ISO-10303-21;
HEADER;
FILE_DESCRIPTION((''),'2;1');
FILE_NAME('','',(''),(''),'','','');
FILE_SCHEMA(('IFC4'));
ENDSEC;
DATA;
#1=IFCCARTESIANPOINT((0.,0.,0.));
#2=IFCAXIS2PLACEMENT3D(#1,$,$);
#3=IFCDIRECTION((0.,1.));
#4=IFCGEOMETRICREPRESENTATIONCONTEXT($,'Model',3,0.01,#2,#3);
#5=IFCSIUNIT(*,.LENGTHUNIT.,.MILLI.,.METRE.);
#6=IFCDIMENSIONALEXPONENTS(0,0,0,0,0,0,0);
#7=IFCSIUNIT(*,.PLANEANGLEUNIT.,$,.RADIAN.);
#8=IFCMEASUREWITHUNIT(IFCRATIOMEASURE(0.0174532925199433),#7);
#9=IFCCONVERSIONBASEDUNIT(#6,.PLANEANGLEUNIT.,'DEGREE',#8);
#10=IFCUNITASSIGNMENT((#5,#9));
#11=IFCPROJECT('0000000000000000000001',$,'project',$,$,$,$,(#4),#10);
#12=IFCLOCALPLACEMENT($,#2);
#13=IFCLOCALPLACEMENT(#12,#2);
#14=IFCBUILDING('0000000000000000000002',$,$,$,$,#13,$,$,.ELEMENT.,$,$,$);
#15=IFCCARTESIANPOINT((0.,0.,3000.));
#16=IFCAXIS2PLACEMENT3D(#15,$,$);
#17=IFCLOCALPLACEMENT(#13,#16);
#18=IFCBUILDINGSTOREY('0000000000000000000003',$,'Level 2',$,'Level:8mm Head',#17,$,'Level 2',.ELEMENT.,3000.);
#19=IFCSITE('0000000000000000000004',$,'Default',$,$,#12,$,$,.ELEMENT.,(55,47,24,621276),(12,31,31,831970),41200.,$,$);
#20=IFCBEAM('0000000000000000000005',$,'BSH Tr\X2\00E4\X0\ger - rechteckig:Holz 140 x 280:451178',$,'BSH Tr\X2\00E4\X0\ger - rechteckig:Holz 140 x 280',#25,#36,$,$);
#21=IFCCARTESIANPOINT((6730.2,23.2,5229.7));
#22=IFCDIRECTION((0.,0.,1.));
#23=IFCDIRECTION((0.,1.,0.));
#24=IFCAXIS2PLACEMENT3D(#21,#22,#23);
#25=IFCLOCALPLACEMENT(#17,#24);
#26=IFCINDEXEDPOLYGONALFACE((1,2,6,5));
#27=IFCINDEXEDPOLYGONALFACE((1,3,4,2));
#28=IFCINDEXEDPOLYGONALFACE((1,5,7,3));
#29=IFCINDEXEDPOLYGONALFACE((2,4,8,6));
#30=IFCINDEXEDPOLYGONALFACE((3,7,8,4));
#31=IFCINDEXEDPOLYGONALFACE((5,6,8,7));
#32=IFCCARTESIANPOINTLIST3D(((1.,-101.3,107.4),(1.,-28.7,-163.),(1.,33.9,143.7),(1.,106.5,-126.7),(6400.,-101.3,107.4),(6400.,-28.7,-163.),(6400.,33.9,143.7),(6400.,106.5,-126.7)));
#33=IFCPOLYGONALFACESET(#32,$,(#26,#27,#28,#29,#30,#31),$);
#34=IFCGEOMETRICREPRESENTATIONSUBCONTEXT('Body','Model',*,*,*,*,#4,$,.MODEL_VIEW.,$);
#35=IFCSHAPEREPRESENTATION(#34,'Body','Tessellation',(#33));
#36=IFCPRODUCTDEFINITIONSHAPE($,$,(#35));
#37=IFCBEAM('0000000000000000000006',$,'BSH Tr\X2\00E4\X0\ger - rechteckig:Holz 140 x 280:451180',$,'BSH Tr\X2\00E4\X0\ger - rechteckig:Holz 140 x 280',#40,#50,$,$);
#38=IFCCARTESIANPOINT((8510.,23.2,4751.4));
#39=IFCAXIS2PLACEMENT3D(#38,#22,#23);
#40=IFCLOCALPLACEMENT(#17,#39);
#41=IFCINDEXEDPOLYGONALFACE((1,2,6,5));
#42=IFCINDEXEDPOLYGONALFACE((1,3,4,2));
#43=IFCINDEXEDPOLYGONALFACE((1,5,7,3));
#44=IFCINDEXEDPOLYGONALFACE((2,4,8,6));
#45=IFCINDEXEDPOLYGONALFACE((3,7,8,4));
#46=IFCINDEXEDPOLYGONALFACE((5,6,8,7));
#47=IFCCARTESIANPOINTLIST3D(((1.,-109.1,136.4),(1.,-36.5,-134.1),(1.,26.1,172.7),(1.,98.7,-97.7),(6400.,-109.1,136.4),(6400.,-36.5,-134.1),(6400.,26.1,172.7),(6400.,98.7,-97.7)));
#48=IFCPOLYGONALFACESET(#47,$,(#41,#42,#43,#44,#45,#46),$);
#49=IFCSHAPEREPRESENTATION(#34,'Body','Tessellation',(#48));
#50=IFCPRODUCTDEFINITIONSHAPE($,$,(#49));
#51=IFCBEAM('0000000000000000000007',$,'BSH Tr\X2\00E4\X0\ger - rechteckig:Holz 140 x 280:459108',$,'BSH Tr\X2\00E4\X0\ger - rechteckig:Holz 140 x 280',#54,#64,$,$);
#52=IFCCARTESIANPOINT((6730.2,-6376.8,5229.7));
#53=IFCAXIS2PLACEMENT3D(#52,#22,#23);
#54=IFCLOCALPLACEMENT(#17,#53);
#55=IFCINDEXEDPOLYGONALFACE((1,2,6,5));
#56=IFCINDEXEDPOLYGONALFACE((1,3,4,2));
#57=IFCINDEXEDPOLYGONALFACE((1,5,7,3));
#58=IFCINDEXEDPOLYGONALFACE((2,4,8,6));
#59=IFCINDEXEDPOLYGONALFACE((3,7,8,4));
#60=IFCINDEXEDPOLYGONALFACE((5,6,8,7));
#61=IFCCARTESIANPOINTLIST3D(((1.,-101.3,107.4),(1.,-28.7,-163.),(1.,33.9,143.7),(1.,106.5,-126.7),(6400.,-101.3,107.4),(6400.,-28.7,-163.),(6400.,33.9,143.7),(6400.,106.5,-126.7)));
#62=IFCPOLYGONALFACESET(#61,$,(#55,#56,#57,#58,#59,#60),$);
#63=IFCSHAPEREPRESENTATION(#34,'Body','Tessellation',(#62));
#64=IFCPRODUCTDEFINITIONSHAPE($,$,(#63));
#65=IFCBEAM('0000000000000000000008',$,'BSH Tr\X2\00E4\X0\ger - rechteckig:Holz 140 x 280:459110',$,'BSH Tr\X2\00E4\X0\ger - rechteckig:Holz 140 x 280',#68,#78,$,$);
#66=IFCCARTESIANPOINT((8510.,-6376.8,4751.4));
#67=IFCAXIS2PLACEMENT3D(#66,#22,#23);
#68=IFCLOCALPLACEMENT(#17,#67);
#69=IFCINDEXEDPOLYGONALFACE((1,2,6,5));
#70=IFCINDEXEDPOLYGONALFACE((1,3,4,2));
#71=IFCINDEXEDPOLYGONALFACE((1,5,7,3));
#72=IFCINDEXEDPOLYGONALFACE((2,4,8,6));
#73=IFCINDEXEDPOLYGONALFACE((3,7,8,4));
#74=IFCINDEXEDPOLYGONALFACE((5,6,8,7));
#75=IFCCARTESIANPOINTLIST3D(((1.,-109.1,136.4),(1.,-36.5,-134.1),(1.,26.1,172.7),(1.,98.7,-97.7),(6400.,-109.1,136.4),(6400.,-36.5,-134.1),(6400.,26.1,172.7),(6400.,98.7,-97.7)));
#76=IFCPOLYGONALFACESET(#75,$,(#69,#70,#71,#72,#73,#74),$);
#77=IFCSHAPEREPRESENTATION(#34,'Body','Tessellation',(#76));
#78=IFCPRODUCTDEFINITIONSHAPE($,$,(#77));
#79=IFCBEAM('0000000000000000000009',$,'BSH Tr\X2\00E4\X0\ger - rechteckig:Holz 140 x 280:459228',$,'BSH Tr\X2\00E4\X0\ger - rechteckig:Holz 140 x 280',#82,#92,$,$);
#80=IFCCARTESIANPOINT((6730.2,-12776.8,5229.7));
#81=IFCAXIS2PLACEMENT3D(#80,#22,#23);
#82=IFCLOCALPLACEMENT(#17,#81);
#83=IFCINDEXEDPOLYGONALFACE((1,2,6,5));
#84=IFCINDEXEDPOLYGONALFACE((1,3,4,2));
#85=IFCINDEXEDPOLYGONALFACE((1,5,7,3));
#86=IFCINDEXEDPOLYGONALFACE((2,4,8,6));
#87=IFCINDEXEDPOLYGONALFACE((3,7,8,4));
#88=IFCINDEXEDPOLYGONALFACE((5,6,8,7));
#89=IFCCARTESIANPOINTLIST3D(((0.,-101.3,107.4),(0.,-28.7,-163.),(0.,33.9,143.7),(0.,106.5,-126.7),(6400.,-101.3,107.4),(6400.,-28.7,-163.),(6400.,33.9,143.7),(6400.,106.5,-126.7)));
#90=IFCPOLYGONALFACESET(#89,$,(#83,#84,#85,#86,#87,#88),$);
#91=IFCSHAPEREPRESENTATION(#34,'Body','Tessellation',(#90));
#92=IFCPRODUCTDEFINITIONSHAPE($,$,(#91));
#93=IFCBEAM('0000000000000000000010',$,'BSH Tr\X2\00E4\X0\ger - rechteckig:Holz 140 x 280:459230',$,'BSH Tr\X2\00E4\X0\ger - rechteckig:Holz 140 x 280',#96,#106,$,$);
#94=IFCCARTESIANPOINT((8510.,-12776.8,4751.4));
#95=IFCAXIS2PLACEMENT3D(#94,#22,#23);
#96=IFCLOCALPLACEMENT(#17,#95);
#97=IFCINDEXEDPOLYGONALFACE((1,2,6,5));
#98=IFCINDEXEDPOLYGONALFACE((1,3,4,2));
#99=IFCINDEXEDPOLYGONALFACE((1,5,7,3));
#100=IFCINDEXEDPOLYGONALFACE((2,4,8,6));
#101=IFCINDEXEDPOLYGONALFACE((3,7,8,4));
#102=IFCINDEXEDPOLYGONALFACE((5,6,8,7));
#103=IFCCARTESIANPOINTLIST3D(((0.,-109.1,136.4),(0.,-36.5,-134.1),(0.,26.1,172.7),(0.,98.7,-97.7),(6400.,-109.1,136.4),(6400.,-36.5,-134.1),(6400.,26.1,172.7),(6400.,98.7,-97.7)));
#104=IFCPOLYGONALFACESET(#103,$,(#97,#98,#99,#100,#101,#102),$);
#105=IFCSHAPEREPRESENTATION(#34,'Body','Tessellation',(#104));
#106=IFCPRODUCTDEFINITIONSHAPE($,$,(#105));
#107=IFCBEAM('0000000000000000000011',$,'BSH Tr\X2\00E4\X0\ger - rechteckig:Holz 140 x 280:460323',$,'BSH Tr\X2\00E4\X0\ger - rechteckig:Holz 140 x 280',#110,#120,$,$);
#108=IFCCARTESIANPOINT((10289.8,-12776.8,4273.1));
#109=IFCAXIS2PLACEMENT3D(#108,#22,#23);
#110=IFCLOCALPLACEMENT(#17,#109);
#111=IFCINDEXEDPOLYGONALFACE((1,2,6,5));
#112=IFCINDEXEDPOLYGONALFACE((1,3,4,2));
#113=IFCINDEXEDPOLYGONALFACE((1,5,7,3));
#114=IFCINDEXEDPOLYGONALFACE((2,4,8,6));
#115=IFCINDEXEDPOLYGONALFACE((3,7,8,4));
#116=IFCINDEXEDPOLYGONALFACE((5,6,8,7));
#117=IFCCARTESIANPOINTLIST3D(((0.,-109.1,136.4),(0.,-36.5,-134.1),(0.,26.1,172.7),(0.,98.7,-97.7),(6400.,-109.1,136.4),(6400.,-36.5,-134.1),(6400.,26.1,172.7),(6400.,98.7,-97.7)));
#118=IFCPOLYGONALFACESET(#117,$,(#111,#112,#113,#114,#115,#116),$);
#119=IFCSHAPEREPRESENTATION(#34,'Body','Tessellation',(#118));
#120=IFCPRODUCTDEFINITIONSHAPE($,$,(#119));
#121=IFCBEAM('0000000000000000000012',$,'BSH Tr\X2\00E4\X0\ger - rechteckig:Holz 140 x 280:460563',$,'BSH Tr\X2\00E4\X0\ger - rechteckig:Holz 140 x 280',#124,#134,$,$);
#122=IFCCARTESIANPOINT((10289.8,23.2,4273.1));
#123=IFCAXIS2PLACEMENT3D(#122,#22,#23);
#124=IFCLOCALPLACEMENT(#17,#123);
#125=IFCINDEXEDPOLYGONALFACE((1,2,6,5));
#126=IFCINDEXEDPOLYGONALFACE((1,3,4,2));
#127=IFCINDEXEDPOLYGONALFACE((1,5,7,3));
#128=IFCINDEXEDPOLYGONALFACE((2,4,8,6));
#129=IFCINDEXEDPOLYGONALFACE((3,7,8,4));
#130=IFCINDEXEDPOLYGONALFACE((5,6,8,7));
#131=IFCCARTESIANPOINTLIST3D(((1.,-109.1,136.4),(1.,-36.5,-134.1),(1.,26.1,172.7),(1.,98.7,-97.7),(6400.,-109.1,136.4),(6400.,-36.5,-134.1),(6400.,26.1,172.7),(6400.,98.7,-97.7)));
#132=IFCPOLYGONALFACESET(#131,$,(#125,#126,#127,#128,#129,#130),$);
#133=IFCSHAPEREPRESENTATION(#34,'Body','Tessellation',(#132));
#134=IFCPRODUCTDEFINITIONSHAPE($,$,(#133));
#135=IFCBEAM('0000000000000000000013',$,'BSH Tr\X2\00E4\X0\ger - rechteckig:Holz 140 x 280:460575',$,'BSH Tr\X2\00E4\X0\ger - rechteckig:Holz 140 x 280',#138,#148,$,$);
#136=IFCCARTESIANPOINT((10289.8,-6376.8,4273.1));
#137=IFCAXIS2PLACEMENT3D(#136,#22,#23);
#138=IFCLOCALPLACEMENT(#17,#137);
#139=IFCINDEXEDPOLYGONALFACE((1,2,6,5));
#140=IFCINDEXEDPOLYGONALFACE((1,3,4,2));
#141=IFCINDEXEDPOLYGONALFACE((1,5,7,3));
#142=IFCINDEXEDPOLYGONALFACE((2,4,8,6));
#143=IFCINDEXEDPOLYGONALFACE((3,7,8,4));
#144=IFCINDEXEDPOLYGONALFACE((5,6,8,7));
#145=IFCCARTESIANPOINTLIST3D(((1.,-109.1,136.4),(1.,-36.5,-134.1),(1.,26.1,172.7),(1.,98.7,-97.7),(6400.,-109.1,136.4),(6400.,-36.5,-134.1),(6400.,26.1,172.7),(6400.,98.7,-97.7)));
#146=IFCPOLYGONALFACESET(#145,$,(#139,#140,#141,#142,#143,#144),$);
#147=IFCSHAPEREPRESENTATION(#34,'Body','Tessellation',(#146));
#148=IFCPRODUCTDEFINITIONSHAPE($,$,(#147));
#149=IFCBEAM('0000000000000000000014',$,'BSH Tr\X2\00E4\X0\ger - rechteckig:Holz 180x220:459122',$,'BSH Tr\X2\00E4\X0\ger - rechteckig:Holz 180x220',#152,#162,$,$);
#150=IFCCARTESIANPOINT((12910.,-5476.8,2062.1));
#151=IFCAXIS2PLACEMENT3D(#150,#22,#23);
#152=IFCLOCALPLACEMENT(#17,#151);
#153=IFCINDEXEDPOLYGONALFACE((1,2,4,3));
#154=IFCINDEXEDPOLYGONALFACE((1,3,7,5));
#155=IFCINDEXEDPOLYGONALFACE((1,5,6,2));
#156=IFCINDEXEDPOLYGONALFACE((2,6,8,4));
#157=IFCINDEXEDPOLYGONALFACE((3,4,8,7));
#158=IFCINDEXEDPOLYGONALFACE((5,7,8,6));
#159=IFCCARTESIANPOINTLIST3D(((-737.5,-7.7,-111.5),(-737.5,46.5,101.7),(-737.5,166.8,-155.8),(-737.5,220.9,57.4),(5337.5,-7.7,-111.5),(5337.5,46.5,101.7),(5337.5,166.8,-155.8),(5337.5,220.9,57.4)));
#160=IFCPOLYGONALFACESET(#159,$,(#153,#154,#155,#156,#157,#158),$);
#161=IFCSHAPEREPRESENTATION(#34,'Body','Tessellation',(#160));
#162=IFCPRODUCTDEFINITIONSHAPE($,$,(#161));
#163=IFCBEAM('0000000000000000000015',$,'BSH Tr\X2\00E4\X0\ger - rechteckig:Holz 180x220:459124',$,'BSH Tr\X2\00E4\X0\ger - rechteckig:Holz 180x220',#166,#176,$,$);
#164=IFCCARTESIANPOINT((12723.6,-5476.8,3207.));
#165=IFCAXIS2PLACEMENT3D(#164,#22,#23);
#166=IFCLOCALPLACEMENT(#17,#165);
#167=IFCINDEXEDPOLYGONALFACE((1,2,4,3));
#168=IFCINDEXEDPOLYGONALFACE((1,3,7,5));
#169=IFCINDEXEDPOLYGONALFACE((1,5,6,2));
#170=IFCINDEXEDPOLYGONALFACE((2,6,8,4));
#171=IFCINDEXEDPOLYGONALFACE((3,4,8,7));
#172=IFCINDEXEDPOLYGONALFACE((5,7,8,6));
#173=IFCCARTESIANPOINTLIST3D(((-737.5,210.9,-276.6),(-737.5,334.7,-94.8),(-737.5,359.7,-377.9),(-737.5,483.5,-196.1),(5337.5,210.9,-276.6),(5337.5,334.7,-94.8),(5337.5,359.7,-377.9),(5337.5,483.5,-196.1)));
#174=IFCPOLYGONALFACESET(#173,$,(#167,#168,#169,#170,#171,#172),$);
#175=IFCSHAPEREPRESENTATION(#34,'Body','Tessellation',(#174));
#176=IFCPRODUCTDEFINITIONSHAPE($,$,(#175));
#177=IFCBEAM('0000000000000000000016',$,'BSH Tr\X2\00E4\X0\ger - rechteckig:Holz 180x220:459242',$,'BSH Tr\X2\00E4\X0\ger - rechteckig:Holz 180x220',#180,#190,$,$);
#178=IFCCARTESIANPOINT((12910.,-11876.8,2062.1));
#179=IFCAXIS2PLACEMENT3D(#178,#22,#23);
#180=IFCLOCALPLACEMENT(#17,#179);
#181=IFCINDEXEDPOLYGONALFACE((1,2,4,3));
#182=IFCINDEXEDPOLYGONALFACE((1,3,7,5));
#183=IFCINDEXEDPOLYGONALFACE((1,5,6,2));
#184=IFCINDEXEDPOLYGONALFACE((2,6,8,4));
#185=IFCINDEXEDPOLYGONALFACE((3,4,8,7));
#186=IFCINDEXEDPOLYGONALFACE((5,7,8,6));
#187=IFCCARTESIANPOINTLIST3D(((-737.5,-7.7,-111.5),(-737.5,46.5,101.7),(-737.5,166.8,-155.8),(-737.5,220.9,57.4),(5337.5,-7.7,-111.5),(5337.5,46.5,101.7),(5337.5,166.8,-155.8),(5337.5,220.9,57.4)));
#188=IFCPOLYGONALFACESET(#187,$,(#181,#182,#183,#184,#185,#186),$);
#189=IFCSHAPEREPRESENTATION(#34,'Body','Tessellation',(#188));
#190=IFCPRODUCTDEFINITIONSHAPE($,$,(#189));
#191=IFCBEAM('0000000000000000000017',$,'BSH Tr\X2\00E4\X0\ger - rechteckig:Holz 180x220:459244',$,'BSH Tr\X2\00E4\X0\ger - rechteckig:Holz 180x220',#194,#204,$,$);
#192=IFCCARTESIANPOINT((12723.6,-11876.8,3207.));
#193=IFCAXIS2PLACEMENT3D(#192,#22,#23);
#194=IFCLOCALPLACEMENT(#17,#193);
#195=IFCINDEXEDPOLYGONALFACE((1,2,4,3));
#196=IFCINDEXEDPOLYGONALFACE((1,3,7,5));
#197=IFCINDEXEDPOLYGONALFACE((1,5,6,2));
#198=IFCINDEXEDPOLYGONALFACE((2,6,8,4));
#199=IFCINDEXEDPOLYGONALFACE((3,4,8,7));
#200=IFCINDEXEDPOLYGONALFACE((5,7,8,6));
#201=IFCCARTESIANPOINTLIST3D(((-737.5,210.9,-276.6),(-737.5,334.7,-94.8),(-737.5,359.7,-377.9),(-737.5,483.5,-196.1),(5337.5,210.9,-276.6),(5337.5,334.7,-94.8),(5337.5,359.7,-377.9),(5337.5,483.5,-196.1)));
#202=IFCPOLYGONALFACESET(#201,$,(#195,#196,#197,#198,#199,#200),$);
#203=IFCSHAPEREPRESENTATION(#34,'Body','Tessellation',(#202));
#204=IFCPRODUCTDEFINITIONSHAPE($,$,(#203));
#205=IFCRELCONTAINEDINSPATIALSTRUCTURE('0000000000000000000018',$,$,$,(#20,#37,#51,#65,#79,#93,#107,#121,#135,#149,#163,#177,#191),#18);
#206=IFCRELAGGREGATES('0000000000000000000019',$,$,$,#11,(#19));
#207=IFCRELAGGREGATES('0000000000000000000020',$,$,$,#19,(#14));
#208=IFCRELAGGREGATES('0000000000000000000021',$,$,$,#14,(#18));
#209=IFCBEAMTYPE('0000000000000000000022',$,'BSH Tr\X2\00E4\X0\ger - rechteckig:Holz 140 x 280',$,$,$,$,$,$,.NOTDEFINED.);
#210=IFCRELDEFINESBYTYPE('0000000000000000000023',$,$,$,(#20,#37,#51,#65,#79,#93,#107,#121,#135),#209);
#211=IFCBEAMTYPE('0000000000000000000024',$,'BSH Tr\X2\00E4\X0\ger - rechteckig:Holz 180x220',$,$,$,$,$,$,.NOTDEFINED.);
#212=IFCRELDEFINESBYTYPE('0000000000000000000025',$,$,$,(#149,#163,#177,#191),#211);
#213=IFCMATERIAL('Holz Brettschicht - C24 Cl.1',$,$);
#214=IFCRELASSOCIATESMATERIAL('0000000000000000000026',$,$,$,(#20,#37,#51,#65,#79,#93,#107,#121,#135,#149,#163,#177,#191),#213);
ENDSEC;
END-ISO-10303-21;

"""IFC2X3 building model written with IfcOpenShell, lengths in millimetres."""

from ifc_helpers import new_model, entity, si_unit, converted_unit, direction, frame, frame_2d, origin, place, context, subcontext, project, spatial, rectangle, extrude, material, type_object, element, save


model = new_model("IFC2X3")

# Units and contexts
model_context = context("Model", 3, precision=0.01, world=origin(), true_north=direction((0.0, 1.0)))
body_context = subcontext(model_context, "Body", "Model", "MODEL_VIEW")
ifc_project = project(units=[si_unit("LENGTHUNIT", "METRE", prefix="MILLI"), converted_unit("PLANEANGLEUNIT", "DEGREE", entity("IfcRatioMeasure", 0.0174532925199433), si_unit("PLANEANGLEUNIT", "RADIAN"), dimensions=[0, 0, 0, 0, 0, 0, 0])], contexts=[model_context])

# Site, building, storey
site_placement = place(None, origin())
site = spatial("IfcSite", under=ifc_project, at=site_placement, Name="Default", CompositionType="ELEMENT", RefLatitude=(55, 47, 24, 621276), RefLongitude=(12, 31, 31, 831970), RefElevation=41200.0)
building_placement = place(site_placement, origin())
building = spatial("IfcBuilding", under=site, at=building_placement, CompositionType="ELEMENT")
storey_placement = place(building_placement, frame((0.0, 0.0, 3000.0)))
storey = spatial("IfcBuildingStorey", under=building, at=storey_placement, Name="Level 2", ObjectType="Level:8mm Head", LongName="Level 2", CompositionType="ELEMENT", Elevation=3000.0)

# Beams
ifc_material = material(Name="Holz Brettschicht - C24 Cl.1")
beam_type_1 = type_object("IfcBeamType", Name="BSH Träger - rechteckig:Holz 140 x 280", PredefinedType="NOTDEFINED")
beam_1_placement = place(storey_placement, frame((6730.2, 23.2, 5229.7), z_axis=(0.0, 0.0, 1.0), x_axis=(0.0, 1.0, 0.0)))
element("IfcBeam", 1, at=beam_1_placement, inside=storey, type_object=beam_type_1, material=ifc_material, Name="BSH Träger - rechteckig:Holz 140 x 280:451178", ObjectType="BSH Träger - rechteckig:Holz 140 x 280", context=body_context, shape_type="SweptSolid", body=[
    extrude(rectangle(XDim=280.0, YDim=140.0, at=frame_2d((0.0, 0.0), x_axis=(1.0, 0.0))), frame((1.0, 2.6, -9.7), z_axis=(1.0, 0.0, 0.0), x_axis=(0.0, -0.259528, 0.965735)), (0.0, 0.0, 1.0), 6399.0),
])
beam_2_placement = place(storey_placement, frame((8510.0, 23.2, 4751.4), z_axis=(0.0, 0.0, 1.0), x_axis=(0.0, 1.0, 0.0)))
element("IfcBeam", 2, at=beam_2_placement, inside=storey, type_object=beam_type_1, material=ifc_material, Name="BSH Träger - rechteckig:Holz 140 x 280:451180", ObjectType="BSH Träger - rechteckig:Holz 140 x 280", context=body_context, shape_type="SweptSolid", body=[
    extrude(rectangle(XDim=280.0, YDim=140.0, at=frame_2d((0.0, 0.0), x_axis=(1.0, 0.0))), frame((1.0, -5.2, 19.3), z_axis=(1.0, 0.0, 0.0), x_axis=(0.0, -0.259528, 0.965735)), (0.0, 0.0, 1.0), 6399.0),
])
beam_3_placement = place(storey_placement, frame((6730.2, -6376.8, 5229.7), z_axis=(0.0, 0.0, 1.0), x_axis=(0.0, 1.0, 0.0)))
element("IfcBeam", 3, at=beam_3_placement, inside=storey, type_object=beam_type_1, material=ifc_material, Name="BSH Träger - rechteckig:Holz 140 x 280:459108", ObjectType="BSH Träger - rechteckig:Holz 140 x 280", context=body_context, shape_type="SweptSolid", body=[
    extrude(rectangle(XDim=280.0, YDim=140.0, at=frame_2d((0.0, 0.0), x_axis=(1.0, 0.0))), frame((1.0, 2.6, -9.7), z_axis=(1.0, 0.0, 0.0), x_axis=(0.0, -0.259528, 0.965735)), (0.0, 0.0, 1.0), 6399.0),
])
beam_4_placement = place(storey_placement, frame((8510.0, -6376.8, 4751.4), z_axis=(0.0, 0.0, 1.0), x_axis=(0.0, 1.0, 0.0)))
element("IfcBeam", 4, at=beam_4_placement, inside=storey, type_object=beam_type_1, material=ifc_material, Name="BSH Träger - rechteckig:Holz 140 x 280:459110", ObjectType="BSH Träger - rechteckig:Holz 140 x 280", context=body_context, shape_type="SweptSolid", body=[
    extrude(rectangle(XDim=280.0, YDim=140.0, at=frame_2d((0.0, 0.0), x_axis=(1.0, 0.0))), frame((1.0, -5.2, 19.3), z_axis=(1.0, 0.0, 0.0), x_axis=(0.0, -0.259528, 0.965735)), (0.0, 0.0, 1.0), 6399.0),
])
beam_5_placement = place(storey_placement, frame((6730.2, -12776.8, 5229.7), z_axis=(0.0, 0.0, 1.0), x_axis=(0.0, 1.0, 0.0)))
element("IfcBeam", 5, at=beam_5_placement, inside=storey, type_object=beam_type_1, material=ifc_material, Name="BSH Träger - rechteckig:Holz 140 x 280:459228", ObjectType="BSH Träger - rechteckig:Holz 140 x 280", context=body_context, shape_type="SweptSolid", body=[
    extrude(rectangle(XDim=280.0, YDim=140.0, at=frame_2d((0.0, 0.0), x_axis=(1.0, 0.0))), frame((0.0, 2.6, -9.7), z_axis=(1.0, 0.0, 0.0), x_axis=(0.0, -0.259528, 0.965735)), (0.0, 0.0, 1.0), 6400.0),
])
beam_6_placement = place(storey_placement, frame((8510.0, -12776.8, 4751.4), z_axis=(0.0, 0.0, 1.0), x_axis=(0.0, 1.0, 0.0)))
element("IfcBeam", 6, at=beam_6_placement, inside=storey, type_object=beam_type_1, material=ifc_material, Name="BSH Träger - rechteckig:Holz 140 x 280:459230", ObjectType="BSH Träger - rechteckig:Holz 140 x 280", context=body_context, shape_type="SweptSolid", body=[
    extrude(rectangle(XDim=280.0, YDim=140.0, at=frame_2d((0.0, 0.0), x_axis=(1.0, 0.0))), frame((0.0, -5.2, 19.3), z_axis=(1.0, 0.0, 0.0), x_axis=(0.0, -0.259528, 0.965735)), (0.0, 0.0, 1.0), 6400.0),
])
beam_7_placement = place(storey_placement, frame((10289.8, -12776.8, 4273.1), z_axis=(0.0, 0.0, 1.0), x_axis=(0.0, 1.0, 0.0)))
element("IfcBeam", 7, at=beam_7_placement, inside=storey, type_object=beam_type_1, material=ifc_material, Name="BSH Träger - rechteckig:Holz 140 x 280:460323", ObjectType="BSH Träger - rechteckig:Holz 140 x 280", context=body_context, shape_type="SweptSolid", body=[
    extrude(rectangle(XDim=280.0, YDim=140.0, at=frame_2d((0.0, 0.0), x_axis=(1.0, 0.0))), frame((0.0, -5.2, 19.3), z_axis=(1.0, 0.0, 0.0), x_axis=(0.0, -0.259528, 0.965735)), (0.0, 0.0, 1.0), 6400.0),
])
beam_8_placement = place(storey_placement, frame((10289.8, 23.2, 4273.1), z_axis=(0.0, 0.0, 1.0), x_axis=(0.0, 1.0, 0.0)))
element("IfcBeam", 8, at=beam_8_placement, inside=storey, type_object=beam_type_1, material=ifc_material, Name="BSH Träger - rechteckig:Holz 140 x 280:460563", ObjectType="BSH Träger - rechteckig:Holz 140 x 280", context=body_context, shape_type="SweptSolid", body=[
    extrude(rectangle(XDim=280.0, YDim=140.0, at=frame_2d((0.0, 0.0), x_axis=(1.0, 0.0))), frame((1.0, -5.2, 19.3), z_axis=(1.0, 0.0, 0.0), x_axis=(0.0, -0.259528, 0.965735)), (0.0, 0.0, 1.0), 6399.0),
])
beam_9_placement = place(storey_placement, frame((10289.8, -6376.8, 4273.1), z_axis=(0.0, 0.0, 1.0), x_axis=(0.0, 1.0, 0.0)))
element("IfcBeam", 9, at=beam_9_placement, inside=storey, type_object=beam_type_1, material=ifc_material, Name="BSH Träger - rechteckig:Holz 140 x 280:460575", ObjectType="BSH Träger - rechteckig:Holz 140 x 280", context=body_context, shape_type="SweptSolid", body=[
    extrude(rectangle(XDim=280.0, YDim=140.0, at=frame_2d((0.0, 0.0), x_axis=(1.0, 0.0))), frame((1.0, -5.2, 19.3), z_axis=(1.0, 0.0, 0.0), x_axis=(0.0, -0.259528, 0.965735)), (0.0, 0.0, 1.0), 6399.0),
])
beam_type_2 = type_object("IfcBeamType", Name="BSH Träger - rechteckig:Holz 180x220", PredefinedType="NOTDEFINED")
beam_10_placement = place(storey_placement, frame((12910.0, -5476.8, 2062.1), z_axis=(0.0, 0.0, 1.0), x_axis=(0.0, 1.0, 0.0)))
element("IfcBeam", 10, at=beam_10_placement, inside=storey, type_object=beam_type_2, material=ifc_material, Name="BSH Träger - rechteckig:Holz 180x220:459122", ObjectType="BSH Träger - rechteckig:Holz 180x220", context=body_context, shape_type="SweptSolid", body=[
    extrude(rectangle(XDim=220.0, YDim=180.0, at=frame_2d((0.0, 0.0), x_axis=(1.0, 0.0))), frame((-737.5, 106.6, -27.1), z_axis=(1.0, 0.0, 0.0), x_axis=(0.0, 0.246135, 0.969236)), (0.0, 0.0, 1.0), 6075.0),
])
beam_11_placement = place(storey_placement, frame((12723.6, -5476.8, 3207.0), z_axis=(0.0, 0.0, 1.0), x_axis=(0.0, 1.0, 0.0)))
element("IfcBeam", 11, at=beam_11_placement, inside=storey, type_object=beam_type_2, material=ifc_material, Name="BSH Träger - rechteckig:Holz 180x220:459124", ObjectType="BSH Träger - rechteckig:Holz 180x220", context=body_context, shape_type="SweptSolid", body=[
    extrude(rectangle(XDim=220.0, YDim=180.0, at=frame_2d((0.0, 0.0), x_axis=(1.0, 0.0))), frame((-737.5, 347.2, -236.4), z_axis=(1.0, 0.0, 0.0), x_axis=(0.0, 0.562789, 0.826601)), (0.0, 0.0, 1.0), 6075.0),
])
beam_12_placement = place(storey_placement, frame((12910.0, -11876.8, 2062.1), z_axis=(0.0, 0.0, 1.0), x_axis=(0.0, 1.0, 0.0)))
element("IfcBeam", 12, at=beam_12_placement, inside=storey, type_object=beam_type_2, material=ifc_material, Name="BSH Träger - rechteckig:Holz 180x220:459242", ObjectType="BSH Träger - rechteckig:Holz 180x220", context=body_context, shape_type="SweptSolid", body=[
    extrude(rectangle(XDim=220.0, YDim=180.0, at=frame_2d((0.0, 0.0), x_axis=(1.0, 0.0))), frame((-737.5, 106.6, -27.1), z_axis=(1.0, 0.0, 0.0), x_axis=(0.0, 0.246135, 0.969236)), (0.0, 0.0, 1.0), 6075.0),
])
beam_13_placement = place(storey_placement, frame((12723.6, -11876.8, 3207.0), z_axis=(0.0, 0.0, 1.0), x_axis=(0.0, 1.0, 0.0)))
element("IfcBeam", 13, at=beam_13_placement, inside=storey, type_object=beam_type_2, material=ifc_material, Name="BSH Träger - rechteckig:Holz 180x220:459244", ObjectType="BSH Träger - rechteckig:Holz 180x220", context=body_context, shape_type="SweptSolid", body=[
    extrude(rectangle(XDim=220.0, YDim=180.0, at=frame_2d((0.0, 0.0), x_axis=(1.0, 0.0))), frame((-737.5, 347.2, -236.4), z_axis=(1.0, 0.0, 0.0), x_axis=(0.0, 0.562789, 0.826601)), (0.0, 0.0, 1.0), 6075.0),
])

save(model, "model.ifc")
